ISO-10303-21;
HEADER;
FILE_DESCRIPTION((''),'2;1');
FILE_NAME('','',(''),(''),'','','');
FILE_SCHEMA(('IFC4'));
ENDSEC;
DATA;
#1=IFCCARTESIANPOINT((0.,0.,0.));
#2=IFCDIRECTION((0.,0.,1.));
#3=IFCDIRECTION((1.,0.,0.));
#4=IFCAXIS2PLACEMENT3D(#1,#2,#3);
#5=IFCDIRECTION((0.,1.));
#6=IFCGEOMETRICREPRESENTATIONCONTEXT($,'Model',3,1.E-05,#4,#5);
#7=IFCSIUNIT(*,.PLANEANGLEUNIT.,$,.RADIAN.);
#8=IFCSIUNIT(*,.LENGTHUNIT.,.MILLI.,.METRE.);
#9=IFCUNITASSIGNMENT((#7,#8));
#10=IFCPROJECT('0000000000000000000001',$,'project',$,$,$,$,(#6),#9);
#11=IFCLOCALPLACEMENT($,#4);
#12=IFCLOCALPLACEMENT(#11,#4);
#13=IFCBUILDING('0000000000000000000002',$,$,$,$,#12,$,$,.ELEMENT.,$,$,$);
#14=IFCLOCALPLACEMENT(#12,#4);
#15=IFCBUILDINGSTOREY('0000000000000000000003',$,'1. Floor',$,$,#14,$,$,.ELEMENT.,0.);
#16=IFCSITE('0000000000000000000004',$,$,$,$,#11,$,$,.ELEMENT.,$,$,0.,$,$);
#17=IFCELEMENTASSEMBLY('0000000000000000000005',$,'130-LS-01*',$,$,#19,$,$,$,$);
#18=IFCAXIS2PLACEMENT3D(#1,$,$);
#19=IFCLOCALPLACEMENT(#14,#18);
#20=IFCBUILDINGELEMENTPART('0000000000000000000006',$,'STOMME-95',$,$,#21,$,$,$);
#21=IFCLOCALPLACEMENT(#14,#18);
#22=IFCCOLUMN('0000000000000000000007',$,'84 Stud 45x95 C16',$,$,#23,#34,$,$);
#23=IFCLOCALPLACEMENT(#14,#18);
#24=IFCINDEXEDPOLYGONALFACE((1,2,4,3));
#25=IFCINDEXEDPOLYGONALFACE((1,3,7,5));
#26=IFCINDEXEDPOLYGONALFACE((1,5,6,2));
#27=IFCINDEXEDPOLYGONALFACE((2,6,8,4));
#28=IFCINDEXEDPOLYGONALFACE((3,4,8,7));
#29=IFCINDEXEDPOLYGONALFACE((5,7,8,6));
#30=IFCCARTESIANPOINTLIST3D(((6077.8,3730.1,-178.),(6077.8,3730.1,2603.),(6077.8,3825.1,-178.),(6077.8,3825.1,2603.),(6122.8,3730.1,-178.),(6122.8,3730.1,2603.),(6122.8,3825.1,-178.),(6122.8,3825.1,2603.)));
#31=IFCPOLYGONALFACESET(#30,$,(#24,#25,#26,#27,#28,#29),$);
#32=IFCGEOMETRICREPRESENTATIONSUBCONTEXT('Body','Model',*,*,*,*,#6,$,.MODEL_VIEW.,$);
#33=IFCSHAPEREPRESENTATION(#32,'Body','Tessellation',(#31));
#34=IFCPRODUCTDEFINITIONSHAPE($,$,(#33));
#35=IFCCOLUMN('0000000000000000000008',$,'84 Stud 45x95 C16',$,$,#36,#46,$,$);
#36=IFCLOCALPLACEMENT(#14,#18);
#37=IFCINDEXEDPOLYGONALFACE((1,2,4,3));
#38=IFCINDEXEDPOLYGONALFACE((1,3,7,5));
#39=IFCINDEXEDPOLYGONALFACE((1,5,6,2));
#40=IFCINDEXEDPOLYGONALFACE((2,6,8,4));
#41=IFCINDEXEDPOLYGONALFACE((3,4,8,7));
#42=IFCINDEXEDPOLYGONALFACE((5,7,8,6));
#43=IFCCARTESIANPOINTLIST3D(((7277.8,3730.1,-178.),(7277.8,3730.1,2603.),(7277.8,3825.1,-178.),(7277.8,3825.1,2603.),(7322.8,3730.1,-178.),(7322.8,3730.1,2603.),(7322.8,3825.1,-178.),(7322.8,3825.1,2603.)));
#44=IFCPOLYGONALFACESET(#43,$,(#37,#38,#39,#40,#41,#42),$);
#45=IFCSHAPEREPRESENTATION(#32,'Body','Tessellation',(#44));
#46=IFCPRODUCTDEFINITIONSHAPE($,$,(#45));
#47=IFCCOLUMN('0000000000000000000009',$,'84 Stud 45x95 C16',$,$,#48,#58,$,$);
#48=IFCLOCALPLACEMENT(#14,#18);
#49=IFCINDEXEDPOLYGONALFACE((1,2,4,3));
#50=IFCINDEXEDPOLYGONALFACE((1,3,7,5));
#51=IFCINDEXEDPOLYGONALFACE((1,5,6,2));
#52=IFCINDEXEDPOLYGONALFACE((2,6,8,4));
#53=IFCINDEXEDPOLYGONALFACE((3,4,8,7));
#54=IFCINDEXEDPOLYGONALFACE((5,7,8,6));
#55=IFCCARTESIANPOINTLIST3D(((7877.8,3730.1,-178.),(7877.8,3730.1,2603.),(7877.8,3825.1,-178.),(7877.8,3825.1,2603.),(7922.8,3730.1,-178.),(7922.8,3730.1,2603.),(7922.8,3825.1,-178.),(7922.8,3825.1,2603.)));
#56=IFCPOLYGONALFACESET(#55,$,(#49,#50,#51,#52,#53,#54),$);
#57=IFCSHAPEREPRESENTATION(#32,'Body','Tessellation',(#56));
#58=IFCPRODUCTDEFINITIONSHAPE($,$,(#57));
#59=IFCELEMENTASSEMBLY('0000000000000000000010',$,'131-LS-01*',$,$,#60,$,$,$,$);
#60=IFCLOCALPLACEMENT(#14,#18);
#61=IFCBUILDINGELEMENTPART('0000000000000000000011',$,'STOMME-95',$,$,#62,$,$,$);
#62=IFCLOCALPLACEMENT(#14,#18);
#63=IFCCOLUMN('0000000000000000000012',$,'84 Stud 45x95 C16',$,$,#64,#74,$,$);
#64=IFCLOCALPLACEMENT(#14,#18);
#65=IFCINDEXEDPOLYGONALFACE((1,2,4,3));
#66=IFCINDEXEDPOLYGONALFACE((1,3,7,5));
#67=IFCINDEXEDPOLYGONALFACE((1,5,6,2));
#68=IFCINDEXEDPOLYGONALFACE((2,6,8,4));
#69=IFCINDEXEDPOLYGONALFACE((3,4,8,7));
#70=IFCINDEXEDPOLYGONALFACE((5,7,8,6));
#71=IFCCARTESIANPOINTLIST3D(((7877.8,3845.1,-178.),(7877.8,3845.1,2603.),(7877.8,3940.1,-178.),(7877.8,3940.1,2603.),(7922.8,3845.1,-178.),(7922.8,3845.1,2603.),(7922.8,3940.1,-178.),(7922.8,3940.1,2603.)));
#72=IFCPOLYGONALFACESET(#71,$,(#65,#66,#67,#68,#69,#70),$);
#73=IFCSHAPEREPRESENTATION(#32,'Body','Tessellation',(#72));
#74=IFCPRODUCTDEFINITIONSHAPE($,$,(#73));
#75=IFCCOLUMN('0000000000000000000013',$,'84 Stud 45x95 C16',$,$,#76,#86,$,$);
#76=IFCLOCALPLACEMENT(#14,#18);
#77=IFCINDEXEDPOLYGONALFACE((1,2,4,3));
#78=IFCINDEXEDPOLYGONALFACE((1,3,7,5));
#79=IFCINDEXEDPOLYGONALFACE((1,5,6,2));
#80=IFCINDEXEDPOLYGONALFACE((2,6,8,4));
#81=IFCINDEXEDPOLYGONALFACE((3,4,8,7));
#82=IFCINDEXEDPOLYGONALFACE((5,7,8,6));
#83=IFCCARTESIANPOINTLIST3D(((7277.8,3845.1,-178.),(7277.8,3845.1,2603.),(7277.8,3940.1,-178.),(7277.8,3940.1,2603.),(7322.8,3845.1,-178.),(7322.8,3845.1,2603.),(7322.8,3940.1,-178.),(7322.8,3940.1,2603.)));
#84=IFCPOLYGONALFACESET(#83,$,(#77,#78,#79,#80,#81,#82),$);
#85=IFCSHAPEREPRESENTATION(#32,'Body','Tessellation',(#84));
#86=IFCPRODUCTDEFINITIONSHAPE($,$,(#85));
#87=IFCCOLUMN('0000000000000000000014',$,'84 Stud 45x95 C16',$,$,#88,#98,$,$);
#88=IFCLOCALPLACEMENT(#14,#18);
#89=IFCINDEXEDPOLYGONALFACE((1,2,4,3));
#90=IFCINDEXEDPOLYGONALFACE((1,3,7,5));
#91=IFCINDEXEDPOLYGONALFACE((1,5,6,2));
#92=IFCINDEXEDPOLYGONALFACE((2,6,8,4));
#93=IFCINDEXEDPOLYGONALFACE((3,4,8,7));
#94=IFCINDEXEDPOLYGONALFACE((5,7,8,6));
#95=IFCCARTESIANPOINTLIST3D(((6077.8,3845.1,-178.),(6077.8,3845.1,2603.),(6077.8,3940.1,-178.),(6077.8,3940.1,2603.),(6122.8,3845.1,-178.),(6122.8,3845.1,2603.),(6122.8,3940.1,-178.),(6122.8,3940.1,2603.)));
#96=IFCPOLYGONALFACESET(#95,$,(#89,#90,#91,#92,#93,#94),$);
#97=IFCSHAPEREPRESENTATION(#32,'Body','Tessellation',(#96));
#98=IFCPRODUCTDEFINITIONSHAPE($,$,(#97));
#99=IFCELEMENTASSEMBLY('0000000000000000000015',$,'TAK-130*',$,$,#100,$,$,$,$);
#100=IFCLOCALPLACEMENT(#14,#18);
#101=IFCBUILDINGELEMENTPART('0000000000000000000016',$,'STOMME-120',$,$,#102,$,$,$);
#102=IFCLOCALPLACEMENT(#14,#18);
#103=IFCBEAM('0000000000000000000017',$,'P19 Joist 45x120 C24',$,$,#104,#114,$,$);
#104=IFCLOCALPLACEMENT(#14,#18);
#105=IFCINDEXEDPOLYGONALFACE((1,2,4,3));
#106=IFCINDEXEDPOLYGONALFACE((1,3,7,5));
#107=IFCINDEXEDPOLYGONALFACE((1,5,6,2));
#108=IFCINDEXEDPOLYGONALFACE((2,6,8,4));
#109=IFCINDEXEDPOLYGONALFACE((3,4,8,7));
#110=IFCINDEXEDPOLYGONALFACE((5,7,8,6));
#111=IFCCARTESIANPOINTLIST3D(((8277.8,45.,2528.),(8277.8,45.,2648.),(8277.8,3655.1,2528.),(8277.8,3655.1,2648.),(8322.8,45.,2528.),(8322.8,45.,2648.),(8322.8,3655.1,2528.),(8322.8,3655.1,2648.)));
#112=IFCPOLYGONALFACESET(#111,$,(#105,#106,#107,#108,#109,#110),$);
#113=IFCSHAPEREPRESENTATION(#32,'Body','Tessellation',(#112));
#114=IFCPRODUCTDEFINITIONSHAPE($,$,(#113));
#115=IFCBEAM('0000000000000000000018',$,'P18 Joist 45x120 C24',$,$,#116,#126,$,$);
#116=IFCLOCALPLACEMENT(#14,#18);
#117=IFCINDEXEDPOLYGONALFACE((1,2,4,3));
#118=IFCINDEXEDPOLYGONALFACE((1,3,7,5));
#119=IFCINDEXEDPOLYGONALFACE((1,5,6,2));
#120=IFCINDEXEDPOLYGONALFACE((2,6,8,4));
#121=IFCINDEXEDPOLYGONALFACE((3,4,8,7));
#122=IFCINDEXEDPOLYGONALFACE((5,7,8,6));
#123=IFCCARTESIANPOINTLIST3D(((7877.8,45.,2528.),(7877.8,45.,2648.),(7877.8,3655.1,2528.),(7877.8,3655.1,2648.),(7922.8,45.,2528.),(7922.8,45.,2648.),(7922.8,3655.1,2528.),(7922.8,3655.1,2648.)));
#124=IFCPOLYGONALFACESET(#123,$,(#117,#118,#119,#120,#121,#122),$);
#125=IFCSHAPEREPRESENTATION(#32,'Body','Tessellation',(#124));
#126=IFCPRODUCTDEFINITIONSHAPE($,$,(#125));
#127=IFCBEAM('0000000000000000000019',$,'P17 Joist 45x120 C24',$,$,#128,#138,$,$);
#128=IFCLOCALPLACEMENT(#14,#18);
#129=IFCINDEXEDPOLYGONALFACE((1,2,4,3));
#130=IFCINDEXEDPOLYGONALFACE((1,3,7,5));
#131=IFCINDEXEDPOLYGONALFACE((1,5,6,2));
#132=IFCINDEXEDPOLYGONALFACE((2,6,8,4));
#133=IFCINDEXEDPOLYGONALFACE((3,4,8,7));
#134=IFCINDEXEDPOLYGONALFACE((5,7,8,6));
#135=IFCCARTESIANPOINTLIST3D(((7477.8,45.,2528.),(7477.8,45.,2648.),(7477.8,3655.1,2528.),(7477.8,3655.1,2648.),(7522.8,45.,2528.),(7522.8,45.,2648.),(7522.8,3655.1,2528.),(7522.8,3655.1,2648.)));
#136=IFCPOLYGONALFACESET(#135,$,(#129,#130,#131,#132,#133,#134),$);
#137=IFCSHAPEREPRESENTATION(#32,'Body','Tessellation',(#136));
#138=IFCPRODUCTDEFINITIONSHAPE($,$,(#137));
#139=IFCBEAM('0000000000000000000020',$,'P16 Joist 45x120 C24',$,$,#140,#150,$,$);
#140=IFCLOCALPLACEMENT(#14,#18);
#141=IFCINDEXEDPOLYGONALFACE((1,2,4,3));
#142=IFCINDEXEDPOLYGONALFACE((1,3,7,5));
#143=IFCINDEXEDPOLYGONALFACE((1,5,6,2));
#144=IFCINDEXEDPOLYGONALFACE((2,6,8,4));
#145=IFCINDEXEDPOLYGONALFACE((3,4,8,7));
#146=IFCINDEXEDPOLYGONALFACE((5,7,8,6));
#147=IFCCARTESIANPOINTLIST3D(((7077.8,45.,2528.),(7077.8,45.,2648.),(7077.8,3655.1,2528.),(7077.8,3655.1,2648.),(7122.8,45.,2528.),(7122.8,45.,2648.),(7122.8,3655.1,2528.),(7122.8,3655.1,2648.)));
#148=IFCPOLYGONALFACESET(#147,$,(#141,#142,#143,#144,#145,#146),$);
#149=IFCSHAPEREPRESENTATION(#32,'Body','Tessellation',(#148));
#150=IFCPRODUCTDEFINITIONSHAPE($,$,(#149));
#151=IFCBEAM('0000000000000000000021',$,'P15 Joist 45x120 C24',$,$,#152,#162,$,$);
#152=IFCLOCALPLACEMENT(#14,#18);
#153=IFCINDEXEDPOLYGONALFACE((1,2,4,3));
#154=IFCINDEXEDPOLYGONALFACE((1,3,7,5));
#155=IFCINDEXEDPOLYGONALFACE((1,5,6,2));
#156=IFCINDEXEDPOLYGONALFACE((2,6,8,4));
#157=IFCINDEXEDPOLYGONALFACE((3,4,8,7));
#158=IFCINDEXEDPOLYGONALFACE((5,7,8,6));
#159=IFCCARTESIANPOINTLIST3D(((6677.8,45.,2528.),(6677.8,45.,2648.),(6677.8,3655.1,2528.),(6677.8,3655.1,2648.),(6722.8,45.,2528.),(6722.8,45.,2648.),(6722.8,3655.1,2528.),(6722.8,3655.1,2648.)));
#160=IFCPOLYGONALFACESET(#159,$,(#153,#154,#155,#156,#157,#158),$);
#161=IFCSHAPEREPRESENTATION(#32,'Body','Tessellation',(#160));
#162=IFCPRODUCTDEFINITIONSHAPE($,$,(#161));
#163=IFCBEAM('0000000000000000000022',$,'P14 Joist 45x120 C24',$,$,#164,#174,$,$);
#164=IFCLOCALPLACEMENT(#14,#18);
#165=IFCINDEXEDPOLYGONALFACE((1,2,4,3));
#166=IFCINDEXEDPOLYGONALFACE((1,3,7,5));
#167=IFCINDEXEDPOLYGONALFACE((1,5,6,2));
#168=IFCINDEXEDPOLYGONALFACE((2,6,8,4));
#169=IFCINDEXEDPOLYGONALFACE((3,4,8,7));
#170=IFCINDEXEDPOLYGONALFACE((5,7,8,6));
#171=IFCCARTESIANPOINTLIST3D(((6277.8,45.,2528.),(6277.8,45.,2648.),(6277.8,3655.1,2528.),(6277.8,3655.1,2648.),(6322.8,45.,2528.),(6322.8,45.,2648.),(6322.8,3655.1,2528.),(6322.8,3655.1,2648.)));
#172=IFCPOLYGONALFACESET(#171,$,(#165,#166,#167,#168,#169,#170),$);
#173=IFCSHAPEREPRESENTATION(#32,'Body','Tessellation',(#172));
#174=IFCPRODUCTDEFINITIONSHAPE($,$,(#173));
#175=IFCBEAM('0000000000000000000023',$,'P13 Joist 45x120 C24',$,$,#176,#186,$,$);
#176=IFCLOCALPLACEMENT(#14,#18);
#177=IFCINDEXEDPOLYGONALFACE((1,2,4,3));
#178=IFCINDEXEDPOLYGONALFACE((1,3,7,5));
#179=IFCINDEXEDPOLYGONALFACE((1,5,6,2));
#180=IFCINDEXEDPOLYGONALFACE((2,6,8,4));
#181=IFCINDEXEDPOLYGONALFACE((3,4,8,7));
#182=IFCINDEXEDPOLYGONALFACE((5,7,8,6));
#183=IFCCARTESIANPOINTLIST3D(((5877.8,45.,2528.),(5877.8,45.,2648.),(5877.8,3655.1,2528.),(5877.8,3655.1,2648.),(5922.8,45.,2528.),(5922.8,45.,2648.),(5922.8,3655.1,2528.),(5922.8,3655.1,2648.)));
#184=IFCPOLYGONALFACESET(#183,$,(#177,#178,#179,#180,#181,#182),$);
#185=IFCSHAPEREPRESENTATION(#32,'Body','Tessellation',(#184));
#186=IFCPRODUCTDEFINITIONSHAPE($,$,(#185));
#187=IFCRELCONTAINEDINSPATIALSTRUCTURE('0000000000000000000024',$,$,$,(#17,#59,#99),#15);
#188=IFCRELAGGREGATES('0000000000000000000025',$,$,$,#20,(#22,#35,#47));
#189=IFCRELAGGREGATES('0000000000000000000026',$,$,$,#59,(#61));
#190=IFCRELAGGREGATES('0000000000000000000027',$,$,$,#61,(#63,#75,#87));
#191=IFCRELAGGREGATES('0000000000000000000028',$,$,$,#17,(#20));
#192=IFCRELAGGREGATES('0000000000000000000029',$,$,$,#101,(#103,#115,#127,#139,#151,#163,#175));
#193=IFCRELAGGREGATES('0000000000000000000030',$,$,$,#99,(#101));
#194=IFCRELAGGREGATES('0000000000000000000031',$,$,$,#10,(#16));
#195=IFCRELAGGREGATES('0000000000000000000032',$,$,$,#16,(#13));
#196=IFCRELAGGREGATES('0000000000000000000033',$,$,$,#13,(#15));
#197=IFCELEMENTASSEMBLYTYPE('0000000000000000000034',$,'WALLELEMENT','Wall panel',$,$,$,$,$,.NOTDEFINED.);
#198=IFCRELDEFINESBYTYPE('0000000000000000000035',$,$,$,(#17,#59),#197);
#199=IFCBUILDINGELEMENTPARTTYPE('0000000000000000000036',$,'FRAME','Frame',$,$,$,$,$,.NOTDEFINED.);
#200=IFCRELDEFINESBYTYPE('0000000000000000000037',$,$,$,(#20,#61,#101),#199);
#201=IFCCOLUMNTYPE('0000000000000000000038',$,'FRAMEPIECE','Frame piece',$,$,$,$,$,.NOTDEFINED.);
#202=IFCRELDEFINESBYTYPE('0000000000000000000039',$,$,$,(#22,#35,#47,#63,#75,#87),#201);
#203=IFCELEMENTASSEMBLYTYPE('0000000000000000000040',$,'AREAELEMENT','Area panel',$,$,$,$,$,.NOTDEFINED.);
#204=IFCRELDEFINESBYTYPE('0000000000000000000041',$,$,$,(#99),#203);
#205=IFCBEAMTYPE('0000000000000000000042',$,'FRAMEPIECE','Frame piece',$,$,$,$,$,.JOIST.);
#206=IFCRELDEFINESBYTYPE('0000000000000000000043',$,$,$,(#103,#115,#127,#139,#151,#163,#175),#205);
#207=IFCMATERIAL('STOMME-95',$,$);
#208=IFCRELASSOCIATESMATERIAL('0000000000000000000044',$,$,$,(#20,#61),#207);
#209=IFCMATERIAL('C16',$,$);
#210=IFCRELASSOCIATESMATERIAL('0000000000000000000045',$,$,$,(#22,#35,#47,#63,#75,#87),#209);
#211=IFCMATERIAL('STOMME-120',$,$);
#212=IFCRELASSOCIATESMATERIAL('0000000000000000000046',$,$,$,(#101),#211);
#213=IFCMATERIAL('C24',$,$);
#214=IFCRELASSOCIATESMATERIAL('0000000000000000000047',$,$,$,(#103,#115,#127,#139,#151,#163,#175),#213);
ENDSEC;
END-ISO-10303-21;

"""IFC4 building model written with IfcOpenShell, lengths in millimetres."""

from ifc_helpers import new_model, si_unit, direction, frame, origin_with_axes, origin_2d_with_axis, place, context, subcontext, project, spatial, rectangle, extrude, material, type_object, element, aggregate, save


model = new_model("IFC4")

# Units and contexts
model_context = context("Model", 3, precision=1e-05, world=origin_with_axes(), true_north=direction((0.0, 1.0)))
body_context = subcontext(model_context, "Body", "Model", "MODEL_VIEW")
ifc_project = project(units=[si_unit("PLANEANGLEUNIT", "RADIAN"), si_unit("LENGTHUNIT", "METRE", prefix="MILLI")], contexts=[model_context])

# Site, building, storey
site_placement = place(None, origin_with_axes())
site = spatial("IfcSite", under=ifc_project, at=site_placement, CompositionType="ELEMENT", RefElevation=0.0)
building_placement = place(site_placement, origin_with_axes())
building = spatial("IfcBuilding", under=site, at=building_placement, CompositionType="ELEMENT")
storey_placement = place(building_placement, origin_with_axes())
storey = spatial("IfcBuildingStorey", under=building, at=storey_placement, Name="1. Floor", CompositionType="ELEMENT", Elevation=0.0)

# Element assemblies, building element parts, columns
element_assembly_type_1 = type_object("IfcElementAssemblyType", Name="WALLELEMENT", Description="Wall panel", PredefinedType="NOTDEFINED")
assembly_1_placement = place(storey_placement, origin_with_axes())
assembly_1 = element("IfcElementAssembly", 1, at=assembly_1_placement, inside=storey, type_object=element_assembly_type_1, Name="130-LS-01*")
ifc_material_1 = material(Name="STOMME-95")
building_element_part_type_1 = type_object("IfcBuildingElementPartType", Name="FRAME", Description="Frame", PredefinedType="NOTDEFINED")
building_element_part_1_placement = place(storey_placement, origin_with_axes())
building_element_part_1 = element("IfcBuildingElementPart", 2, at=building_element_part_1_placement, type_object=building_element_part_type_1, material=ifc_material_1, Name="STOMME-95")
ifc_material_2 = material(Name="C16")
column_type = type_object("IfcColumnType", Name="FRAMEPIECE", Description="Frame piece", PredefinedType="NOTDEFINED")
column_1_placement = place(storey_placement, frame((6100.3, 3777.6, 2603.0), z_axis=(0.0, 0.0, -1.0), x_axis=(-1.0, 0.0, 0.0)))
column_1 = element("IfcColumn", 3, at=column_1_placement, type_object=column_type, material=ifc_material_2, Name="84 Stud 45x95 C16", context=body_context, shape_type="SweptSolid", body=[
    extrude(rectangle(XDim=45.0, YDim=95.0, at=origin_2d_with_axis()), origin_with_axes(), (0.0, 0.0, 1.0), 2781.0),
])
column_2_placement = place(storey_placement, frame((7300.3, 3777.6, 2603.0), z_axis=(0.0, 0.0, -1.0), x_axis=(-1.0, 0.0, 0.0)))
column_2 = element("IfcColumn", 4, at=column_2_placement, type_object=column_type, material=ifc_material_2, Name="84 Stud 45x95 C16", context=body_context, shape_type="SweptSolid", body=[
    extrude(rectangle(XDim=45.0, YDim=95.0, at=origin_2d_with_axis()), origin_with_axes(), (0.0, 0.0, 1.0), 2781.0),
])
column_3_placement = place(storey_placement, frame((7900.3, 3777.6, 2603.0), z_axis=(0.0, 0.0, -1.0), x_axis=(-1.0, 0.0, 0.0)))
column_3 = element("IfcColumn", 5, at=column_3_placement, type_object=column_type, material=ifc_material_2, Name="84 Stud 45x95 C16", context=body_context, shape_type="SweptSolid", body=[
    extrude(rectangle(XDim=45.0, YDim=95.0, at=origin_2d_with_axis()), origin_with_axes(), (0.0, 0.0, 1.0), 2781.0),
])
aggregate(building_element_part_1, [column_1, column_2, column_3])
assembly_2_placement = place(storey_placement, origin_with_axes())
assembly_2 = element("IfcElementAssembly", 6, at=assembly_2_placement, inside=storey, type_object=element_assembly_type_1, Name="131-LS-01*")
building_element_part_2_placement = place(storey_placement, origin_with_axes())
building_element_part_2 = element("IfcBuildingElementPart", 7, at=building_element_part_2_placement, type_object=building_element_part_type_1, material=ifc_material_1, Name="STOMME-95")
aggregate(assembly_2, [building_element_part_2])
column_4_placement = place(storey_placement, frame((7900.3, 3892.6, 2603.0), z_axis=(0.0, 0.0, -1.0), x_axis=(1.0, 0.0, 0.0)))
column_4 = element("IfcColumn", 8, at=column_4_placement, type_object=column_type, material=ifc_material_2, Name="84 Stud 45x95 C16", context=body_context, shape_type="SweptSolid", body=[
    extrude(rectangle(XDim=45.0, YDim=95.0, at=origin_2d_with_axis()), origin_with_axes(), (0.0, 0.0, 1.0), 2781.0),
])
column_5_placement = place(storey_placement, frame((7300.3, 3892.6, 2603.0), z_axis=(0.0, 0.0, -1.0), x_axis=(1.0, 0.0, 0.0)))
column_5 = element("IfcColumn", 9, at=column_5_placement, type_object=column_type, material=ifc_material_2, Name="84 Stud 45x95 C16", context=body_context, shape_type="SweptSolid", body=[
    extrude(rectangle(XDim=45.0, YDim=95.0, at=origin_2d_with_axis()), origin_with_axes(), (0.0, 0.0, 1.0), 2781.0),
])
column_6_placement = place(storey_placement, frame((6100.3, 3892.6, 2603.0), z_axis=(0.0, 0.0, -1.0), x_axis=(1.0, 0.0, 0.0)))
column_6 = element("IfcColumn", 10, at=column_6_placement, type_object=column_type, material=ifc_material_2, Name="84 Stud 45x95 C16", context=body_context, shape_type="SweptSolid", body=[
    extrude(rectangle(XDim=45.0, YDim=95.0, at=origin_2d_with_axis()), origin_with_axes(), (0.0, 0.0, 1.0), 2781.0),
])
aggregate(building_element_part_2, [column_4, column_5, column_6])

# Element assembly, building element part, beams
element_assembly_type_2 = type_object("IfcElementAssemblyType", Name="AREAELEMENT", Description="Area panel", PredefinedType="NOTDEFINED")
assembly_3_placement = place(storey_placement, origin_with_axes())
assembly_3 = element("IfcElementAssembly", 11, at=assembly_3_placement, inside=storey, type_object=element_assembly_type_2, Name="TAK-130*")
ifc_material_3 = material(Name="STOMME-120")
building_element_part_3_placement = place(storey_placement, origin_with_axes())
building_element_part_3 = element("IfcBuildingElementPart", 12, at=building_element_part_3_placement, type_object=building_element_part_type_1, material=ifc_material_3, Name="STOMME-120")
ifc_material_4 = material(Name="C24")
beam_type = type_object("IfcBeamType", Name="FRAMEPIECE", Description="Frame piece", PredefinedType="JOIST")
beam_1_placement = place(storey_placement, frame((8300.3, 3655.1, 2588.0), z_axis=(0.0, -1.0, 0.0), x_axis=(1.0, 0.0, 0.0)))
beam_1 = element("IfcBeam", 13, at=beam_1_placement, type_object=beam_type, material=ifc_material_4, Name="P19 Joist 45x120 C24", context=body_context, shape_type="SweptSolid", body=[
    extrude(rectangle(XDim=45.0, YDim=120.0, at=origin_2d_with_axis()), origin_with_axes(), (0.0, 0.0, 1.0), 3610.1),
])
beam_2_placement = place(storey_placement, frame((7900.3, 3655.1, 2588.0), z_axis=(0.0, -1.0, 0.0), x_axis=(1.0, 0.0, 0.0)))
beam_2 = element("IfcBeam", 14, at=beam_2_placement, type_object=beam_type, material=ifc_material_4, Name="P18 Joist 45x120 C24", context=body_context, shape_type="SweptSolid", body=[
    extrude(rectangle(XDim=45.0, YDim=120.0, at=origin_2d_with_axis()), origin_with_axes(), (0.0, 0.0, 1.0), 3610.1),
])
beam_3_placement = place(storey_placement, frame((7500.3, 3655.1, 2588.0), z_axis=(0.0, -1.0, 0.0), x_axis=(1.0, 0.0, 0.0)))
beam_3 = element("IfcBeam", 15, at=beam_3_placement, type_object=beam_type, material=ifc_material_4, Name="P17 Joist 45x120 C24", context=body_context, shape_type="SweptSolid", body=[
    extrude(rectangle(XDim=45.0, YDim=120.0, at=origin_2d_with_axis()), origin_with_axes(), (0.0, 0.0, 1.0), 3610.1),
])
beam_4_placement = place(storey_placement, frame((7100.3, 3655.1, 2588.0), z_axis=(0.0, -1.0, 0.0), x_axis=(1.0, 0.0, 0.0)))
beam_4 = element("IfcBeam", 16, at=beam_4_placement, type_object=beam_type, material=ifc_material_4, Name="P16 Joist 45x120 C24", context=body_context, shape_type="SweptSolid", body=[
    extrude(rectangle(XDim=45.0, YDim=120.0, at=origin_2d_with_axis()), origin_with_axes(), (0.0, 0.0, 1.0), 3610.1),
])
beam_5_placement = place(storey_placement, frame((6700.3, 3655.1, 2588.0), z_axis=(0.0, -1.0, 0.0), x_axis=(1.0, 0.0, 0.0)))
beam_5 = element("IfcBeam", 17, at=beam_5_placement, type_object=beam_type, material=ifc_material_4, Name="P15 Joist 45x120 C24", context=body_context, shape_type="SweptSolid", body=[
    extrude(rectangle(XDim=45.0, YDim=120.0, at=origin_2d_with_axis()), origin_with_axes(), (0.0, 0.0, 1.0), 3610.1),
])
beam_6_placement = place(storey_placement, frame((6300.3, 3655.1, 2588.0), z_axis=(0.0, -1.0, 0.0), x_axis=(1.0, 0.0, 0.0)))
beam_6 = element("IfcBeam", 18, at=beam_6_placement, type_object=beam_type, material=ifc_material_4, Name="P14 Joist 45x120 C24", context=body_context, shape_type="SweptSolid", body=[
    extrude(rectangle(XDim=45.0, YDim=120.0, at=origin_2d_with_axis()), origin_with_axes(), (0.0, 0.0, 1.0), 3610.1),
])
beam_7_placement = place(storey_placement, frame((5900.3, 3655.1, 2588.0), z_axis=(0.0, -1.0, 0.0), x_axis=(1.0, 0.0, 0.0)))
beam_7 = element("IfcBeam", 19, at=beam_7_placement, type_object=beam_type, material=ifc_material_4, Name="P13 Joist 45x120 C24", context=body_context, shape_type="SweptSolid", body=[
    extrude(rectangle(XDim=45.0, YDim=120.0, at=origin_2d_with_axis()), origin_with_axes(), (0.0, 0.0, 1.0), 3610.1),
])

aggregate(assembly_1, [building_element_part_1])

aggregate(building_element_part_3, [beam_1, beam_2, beam_3, beam_4, beam_5, beam_6, beam_7])

aggregate(assembly_3, [building_element_part_3])

save(model, "model.ifc")
